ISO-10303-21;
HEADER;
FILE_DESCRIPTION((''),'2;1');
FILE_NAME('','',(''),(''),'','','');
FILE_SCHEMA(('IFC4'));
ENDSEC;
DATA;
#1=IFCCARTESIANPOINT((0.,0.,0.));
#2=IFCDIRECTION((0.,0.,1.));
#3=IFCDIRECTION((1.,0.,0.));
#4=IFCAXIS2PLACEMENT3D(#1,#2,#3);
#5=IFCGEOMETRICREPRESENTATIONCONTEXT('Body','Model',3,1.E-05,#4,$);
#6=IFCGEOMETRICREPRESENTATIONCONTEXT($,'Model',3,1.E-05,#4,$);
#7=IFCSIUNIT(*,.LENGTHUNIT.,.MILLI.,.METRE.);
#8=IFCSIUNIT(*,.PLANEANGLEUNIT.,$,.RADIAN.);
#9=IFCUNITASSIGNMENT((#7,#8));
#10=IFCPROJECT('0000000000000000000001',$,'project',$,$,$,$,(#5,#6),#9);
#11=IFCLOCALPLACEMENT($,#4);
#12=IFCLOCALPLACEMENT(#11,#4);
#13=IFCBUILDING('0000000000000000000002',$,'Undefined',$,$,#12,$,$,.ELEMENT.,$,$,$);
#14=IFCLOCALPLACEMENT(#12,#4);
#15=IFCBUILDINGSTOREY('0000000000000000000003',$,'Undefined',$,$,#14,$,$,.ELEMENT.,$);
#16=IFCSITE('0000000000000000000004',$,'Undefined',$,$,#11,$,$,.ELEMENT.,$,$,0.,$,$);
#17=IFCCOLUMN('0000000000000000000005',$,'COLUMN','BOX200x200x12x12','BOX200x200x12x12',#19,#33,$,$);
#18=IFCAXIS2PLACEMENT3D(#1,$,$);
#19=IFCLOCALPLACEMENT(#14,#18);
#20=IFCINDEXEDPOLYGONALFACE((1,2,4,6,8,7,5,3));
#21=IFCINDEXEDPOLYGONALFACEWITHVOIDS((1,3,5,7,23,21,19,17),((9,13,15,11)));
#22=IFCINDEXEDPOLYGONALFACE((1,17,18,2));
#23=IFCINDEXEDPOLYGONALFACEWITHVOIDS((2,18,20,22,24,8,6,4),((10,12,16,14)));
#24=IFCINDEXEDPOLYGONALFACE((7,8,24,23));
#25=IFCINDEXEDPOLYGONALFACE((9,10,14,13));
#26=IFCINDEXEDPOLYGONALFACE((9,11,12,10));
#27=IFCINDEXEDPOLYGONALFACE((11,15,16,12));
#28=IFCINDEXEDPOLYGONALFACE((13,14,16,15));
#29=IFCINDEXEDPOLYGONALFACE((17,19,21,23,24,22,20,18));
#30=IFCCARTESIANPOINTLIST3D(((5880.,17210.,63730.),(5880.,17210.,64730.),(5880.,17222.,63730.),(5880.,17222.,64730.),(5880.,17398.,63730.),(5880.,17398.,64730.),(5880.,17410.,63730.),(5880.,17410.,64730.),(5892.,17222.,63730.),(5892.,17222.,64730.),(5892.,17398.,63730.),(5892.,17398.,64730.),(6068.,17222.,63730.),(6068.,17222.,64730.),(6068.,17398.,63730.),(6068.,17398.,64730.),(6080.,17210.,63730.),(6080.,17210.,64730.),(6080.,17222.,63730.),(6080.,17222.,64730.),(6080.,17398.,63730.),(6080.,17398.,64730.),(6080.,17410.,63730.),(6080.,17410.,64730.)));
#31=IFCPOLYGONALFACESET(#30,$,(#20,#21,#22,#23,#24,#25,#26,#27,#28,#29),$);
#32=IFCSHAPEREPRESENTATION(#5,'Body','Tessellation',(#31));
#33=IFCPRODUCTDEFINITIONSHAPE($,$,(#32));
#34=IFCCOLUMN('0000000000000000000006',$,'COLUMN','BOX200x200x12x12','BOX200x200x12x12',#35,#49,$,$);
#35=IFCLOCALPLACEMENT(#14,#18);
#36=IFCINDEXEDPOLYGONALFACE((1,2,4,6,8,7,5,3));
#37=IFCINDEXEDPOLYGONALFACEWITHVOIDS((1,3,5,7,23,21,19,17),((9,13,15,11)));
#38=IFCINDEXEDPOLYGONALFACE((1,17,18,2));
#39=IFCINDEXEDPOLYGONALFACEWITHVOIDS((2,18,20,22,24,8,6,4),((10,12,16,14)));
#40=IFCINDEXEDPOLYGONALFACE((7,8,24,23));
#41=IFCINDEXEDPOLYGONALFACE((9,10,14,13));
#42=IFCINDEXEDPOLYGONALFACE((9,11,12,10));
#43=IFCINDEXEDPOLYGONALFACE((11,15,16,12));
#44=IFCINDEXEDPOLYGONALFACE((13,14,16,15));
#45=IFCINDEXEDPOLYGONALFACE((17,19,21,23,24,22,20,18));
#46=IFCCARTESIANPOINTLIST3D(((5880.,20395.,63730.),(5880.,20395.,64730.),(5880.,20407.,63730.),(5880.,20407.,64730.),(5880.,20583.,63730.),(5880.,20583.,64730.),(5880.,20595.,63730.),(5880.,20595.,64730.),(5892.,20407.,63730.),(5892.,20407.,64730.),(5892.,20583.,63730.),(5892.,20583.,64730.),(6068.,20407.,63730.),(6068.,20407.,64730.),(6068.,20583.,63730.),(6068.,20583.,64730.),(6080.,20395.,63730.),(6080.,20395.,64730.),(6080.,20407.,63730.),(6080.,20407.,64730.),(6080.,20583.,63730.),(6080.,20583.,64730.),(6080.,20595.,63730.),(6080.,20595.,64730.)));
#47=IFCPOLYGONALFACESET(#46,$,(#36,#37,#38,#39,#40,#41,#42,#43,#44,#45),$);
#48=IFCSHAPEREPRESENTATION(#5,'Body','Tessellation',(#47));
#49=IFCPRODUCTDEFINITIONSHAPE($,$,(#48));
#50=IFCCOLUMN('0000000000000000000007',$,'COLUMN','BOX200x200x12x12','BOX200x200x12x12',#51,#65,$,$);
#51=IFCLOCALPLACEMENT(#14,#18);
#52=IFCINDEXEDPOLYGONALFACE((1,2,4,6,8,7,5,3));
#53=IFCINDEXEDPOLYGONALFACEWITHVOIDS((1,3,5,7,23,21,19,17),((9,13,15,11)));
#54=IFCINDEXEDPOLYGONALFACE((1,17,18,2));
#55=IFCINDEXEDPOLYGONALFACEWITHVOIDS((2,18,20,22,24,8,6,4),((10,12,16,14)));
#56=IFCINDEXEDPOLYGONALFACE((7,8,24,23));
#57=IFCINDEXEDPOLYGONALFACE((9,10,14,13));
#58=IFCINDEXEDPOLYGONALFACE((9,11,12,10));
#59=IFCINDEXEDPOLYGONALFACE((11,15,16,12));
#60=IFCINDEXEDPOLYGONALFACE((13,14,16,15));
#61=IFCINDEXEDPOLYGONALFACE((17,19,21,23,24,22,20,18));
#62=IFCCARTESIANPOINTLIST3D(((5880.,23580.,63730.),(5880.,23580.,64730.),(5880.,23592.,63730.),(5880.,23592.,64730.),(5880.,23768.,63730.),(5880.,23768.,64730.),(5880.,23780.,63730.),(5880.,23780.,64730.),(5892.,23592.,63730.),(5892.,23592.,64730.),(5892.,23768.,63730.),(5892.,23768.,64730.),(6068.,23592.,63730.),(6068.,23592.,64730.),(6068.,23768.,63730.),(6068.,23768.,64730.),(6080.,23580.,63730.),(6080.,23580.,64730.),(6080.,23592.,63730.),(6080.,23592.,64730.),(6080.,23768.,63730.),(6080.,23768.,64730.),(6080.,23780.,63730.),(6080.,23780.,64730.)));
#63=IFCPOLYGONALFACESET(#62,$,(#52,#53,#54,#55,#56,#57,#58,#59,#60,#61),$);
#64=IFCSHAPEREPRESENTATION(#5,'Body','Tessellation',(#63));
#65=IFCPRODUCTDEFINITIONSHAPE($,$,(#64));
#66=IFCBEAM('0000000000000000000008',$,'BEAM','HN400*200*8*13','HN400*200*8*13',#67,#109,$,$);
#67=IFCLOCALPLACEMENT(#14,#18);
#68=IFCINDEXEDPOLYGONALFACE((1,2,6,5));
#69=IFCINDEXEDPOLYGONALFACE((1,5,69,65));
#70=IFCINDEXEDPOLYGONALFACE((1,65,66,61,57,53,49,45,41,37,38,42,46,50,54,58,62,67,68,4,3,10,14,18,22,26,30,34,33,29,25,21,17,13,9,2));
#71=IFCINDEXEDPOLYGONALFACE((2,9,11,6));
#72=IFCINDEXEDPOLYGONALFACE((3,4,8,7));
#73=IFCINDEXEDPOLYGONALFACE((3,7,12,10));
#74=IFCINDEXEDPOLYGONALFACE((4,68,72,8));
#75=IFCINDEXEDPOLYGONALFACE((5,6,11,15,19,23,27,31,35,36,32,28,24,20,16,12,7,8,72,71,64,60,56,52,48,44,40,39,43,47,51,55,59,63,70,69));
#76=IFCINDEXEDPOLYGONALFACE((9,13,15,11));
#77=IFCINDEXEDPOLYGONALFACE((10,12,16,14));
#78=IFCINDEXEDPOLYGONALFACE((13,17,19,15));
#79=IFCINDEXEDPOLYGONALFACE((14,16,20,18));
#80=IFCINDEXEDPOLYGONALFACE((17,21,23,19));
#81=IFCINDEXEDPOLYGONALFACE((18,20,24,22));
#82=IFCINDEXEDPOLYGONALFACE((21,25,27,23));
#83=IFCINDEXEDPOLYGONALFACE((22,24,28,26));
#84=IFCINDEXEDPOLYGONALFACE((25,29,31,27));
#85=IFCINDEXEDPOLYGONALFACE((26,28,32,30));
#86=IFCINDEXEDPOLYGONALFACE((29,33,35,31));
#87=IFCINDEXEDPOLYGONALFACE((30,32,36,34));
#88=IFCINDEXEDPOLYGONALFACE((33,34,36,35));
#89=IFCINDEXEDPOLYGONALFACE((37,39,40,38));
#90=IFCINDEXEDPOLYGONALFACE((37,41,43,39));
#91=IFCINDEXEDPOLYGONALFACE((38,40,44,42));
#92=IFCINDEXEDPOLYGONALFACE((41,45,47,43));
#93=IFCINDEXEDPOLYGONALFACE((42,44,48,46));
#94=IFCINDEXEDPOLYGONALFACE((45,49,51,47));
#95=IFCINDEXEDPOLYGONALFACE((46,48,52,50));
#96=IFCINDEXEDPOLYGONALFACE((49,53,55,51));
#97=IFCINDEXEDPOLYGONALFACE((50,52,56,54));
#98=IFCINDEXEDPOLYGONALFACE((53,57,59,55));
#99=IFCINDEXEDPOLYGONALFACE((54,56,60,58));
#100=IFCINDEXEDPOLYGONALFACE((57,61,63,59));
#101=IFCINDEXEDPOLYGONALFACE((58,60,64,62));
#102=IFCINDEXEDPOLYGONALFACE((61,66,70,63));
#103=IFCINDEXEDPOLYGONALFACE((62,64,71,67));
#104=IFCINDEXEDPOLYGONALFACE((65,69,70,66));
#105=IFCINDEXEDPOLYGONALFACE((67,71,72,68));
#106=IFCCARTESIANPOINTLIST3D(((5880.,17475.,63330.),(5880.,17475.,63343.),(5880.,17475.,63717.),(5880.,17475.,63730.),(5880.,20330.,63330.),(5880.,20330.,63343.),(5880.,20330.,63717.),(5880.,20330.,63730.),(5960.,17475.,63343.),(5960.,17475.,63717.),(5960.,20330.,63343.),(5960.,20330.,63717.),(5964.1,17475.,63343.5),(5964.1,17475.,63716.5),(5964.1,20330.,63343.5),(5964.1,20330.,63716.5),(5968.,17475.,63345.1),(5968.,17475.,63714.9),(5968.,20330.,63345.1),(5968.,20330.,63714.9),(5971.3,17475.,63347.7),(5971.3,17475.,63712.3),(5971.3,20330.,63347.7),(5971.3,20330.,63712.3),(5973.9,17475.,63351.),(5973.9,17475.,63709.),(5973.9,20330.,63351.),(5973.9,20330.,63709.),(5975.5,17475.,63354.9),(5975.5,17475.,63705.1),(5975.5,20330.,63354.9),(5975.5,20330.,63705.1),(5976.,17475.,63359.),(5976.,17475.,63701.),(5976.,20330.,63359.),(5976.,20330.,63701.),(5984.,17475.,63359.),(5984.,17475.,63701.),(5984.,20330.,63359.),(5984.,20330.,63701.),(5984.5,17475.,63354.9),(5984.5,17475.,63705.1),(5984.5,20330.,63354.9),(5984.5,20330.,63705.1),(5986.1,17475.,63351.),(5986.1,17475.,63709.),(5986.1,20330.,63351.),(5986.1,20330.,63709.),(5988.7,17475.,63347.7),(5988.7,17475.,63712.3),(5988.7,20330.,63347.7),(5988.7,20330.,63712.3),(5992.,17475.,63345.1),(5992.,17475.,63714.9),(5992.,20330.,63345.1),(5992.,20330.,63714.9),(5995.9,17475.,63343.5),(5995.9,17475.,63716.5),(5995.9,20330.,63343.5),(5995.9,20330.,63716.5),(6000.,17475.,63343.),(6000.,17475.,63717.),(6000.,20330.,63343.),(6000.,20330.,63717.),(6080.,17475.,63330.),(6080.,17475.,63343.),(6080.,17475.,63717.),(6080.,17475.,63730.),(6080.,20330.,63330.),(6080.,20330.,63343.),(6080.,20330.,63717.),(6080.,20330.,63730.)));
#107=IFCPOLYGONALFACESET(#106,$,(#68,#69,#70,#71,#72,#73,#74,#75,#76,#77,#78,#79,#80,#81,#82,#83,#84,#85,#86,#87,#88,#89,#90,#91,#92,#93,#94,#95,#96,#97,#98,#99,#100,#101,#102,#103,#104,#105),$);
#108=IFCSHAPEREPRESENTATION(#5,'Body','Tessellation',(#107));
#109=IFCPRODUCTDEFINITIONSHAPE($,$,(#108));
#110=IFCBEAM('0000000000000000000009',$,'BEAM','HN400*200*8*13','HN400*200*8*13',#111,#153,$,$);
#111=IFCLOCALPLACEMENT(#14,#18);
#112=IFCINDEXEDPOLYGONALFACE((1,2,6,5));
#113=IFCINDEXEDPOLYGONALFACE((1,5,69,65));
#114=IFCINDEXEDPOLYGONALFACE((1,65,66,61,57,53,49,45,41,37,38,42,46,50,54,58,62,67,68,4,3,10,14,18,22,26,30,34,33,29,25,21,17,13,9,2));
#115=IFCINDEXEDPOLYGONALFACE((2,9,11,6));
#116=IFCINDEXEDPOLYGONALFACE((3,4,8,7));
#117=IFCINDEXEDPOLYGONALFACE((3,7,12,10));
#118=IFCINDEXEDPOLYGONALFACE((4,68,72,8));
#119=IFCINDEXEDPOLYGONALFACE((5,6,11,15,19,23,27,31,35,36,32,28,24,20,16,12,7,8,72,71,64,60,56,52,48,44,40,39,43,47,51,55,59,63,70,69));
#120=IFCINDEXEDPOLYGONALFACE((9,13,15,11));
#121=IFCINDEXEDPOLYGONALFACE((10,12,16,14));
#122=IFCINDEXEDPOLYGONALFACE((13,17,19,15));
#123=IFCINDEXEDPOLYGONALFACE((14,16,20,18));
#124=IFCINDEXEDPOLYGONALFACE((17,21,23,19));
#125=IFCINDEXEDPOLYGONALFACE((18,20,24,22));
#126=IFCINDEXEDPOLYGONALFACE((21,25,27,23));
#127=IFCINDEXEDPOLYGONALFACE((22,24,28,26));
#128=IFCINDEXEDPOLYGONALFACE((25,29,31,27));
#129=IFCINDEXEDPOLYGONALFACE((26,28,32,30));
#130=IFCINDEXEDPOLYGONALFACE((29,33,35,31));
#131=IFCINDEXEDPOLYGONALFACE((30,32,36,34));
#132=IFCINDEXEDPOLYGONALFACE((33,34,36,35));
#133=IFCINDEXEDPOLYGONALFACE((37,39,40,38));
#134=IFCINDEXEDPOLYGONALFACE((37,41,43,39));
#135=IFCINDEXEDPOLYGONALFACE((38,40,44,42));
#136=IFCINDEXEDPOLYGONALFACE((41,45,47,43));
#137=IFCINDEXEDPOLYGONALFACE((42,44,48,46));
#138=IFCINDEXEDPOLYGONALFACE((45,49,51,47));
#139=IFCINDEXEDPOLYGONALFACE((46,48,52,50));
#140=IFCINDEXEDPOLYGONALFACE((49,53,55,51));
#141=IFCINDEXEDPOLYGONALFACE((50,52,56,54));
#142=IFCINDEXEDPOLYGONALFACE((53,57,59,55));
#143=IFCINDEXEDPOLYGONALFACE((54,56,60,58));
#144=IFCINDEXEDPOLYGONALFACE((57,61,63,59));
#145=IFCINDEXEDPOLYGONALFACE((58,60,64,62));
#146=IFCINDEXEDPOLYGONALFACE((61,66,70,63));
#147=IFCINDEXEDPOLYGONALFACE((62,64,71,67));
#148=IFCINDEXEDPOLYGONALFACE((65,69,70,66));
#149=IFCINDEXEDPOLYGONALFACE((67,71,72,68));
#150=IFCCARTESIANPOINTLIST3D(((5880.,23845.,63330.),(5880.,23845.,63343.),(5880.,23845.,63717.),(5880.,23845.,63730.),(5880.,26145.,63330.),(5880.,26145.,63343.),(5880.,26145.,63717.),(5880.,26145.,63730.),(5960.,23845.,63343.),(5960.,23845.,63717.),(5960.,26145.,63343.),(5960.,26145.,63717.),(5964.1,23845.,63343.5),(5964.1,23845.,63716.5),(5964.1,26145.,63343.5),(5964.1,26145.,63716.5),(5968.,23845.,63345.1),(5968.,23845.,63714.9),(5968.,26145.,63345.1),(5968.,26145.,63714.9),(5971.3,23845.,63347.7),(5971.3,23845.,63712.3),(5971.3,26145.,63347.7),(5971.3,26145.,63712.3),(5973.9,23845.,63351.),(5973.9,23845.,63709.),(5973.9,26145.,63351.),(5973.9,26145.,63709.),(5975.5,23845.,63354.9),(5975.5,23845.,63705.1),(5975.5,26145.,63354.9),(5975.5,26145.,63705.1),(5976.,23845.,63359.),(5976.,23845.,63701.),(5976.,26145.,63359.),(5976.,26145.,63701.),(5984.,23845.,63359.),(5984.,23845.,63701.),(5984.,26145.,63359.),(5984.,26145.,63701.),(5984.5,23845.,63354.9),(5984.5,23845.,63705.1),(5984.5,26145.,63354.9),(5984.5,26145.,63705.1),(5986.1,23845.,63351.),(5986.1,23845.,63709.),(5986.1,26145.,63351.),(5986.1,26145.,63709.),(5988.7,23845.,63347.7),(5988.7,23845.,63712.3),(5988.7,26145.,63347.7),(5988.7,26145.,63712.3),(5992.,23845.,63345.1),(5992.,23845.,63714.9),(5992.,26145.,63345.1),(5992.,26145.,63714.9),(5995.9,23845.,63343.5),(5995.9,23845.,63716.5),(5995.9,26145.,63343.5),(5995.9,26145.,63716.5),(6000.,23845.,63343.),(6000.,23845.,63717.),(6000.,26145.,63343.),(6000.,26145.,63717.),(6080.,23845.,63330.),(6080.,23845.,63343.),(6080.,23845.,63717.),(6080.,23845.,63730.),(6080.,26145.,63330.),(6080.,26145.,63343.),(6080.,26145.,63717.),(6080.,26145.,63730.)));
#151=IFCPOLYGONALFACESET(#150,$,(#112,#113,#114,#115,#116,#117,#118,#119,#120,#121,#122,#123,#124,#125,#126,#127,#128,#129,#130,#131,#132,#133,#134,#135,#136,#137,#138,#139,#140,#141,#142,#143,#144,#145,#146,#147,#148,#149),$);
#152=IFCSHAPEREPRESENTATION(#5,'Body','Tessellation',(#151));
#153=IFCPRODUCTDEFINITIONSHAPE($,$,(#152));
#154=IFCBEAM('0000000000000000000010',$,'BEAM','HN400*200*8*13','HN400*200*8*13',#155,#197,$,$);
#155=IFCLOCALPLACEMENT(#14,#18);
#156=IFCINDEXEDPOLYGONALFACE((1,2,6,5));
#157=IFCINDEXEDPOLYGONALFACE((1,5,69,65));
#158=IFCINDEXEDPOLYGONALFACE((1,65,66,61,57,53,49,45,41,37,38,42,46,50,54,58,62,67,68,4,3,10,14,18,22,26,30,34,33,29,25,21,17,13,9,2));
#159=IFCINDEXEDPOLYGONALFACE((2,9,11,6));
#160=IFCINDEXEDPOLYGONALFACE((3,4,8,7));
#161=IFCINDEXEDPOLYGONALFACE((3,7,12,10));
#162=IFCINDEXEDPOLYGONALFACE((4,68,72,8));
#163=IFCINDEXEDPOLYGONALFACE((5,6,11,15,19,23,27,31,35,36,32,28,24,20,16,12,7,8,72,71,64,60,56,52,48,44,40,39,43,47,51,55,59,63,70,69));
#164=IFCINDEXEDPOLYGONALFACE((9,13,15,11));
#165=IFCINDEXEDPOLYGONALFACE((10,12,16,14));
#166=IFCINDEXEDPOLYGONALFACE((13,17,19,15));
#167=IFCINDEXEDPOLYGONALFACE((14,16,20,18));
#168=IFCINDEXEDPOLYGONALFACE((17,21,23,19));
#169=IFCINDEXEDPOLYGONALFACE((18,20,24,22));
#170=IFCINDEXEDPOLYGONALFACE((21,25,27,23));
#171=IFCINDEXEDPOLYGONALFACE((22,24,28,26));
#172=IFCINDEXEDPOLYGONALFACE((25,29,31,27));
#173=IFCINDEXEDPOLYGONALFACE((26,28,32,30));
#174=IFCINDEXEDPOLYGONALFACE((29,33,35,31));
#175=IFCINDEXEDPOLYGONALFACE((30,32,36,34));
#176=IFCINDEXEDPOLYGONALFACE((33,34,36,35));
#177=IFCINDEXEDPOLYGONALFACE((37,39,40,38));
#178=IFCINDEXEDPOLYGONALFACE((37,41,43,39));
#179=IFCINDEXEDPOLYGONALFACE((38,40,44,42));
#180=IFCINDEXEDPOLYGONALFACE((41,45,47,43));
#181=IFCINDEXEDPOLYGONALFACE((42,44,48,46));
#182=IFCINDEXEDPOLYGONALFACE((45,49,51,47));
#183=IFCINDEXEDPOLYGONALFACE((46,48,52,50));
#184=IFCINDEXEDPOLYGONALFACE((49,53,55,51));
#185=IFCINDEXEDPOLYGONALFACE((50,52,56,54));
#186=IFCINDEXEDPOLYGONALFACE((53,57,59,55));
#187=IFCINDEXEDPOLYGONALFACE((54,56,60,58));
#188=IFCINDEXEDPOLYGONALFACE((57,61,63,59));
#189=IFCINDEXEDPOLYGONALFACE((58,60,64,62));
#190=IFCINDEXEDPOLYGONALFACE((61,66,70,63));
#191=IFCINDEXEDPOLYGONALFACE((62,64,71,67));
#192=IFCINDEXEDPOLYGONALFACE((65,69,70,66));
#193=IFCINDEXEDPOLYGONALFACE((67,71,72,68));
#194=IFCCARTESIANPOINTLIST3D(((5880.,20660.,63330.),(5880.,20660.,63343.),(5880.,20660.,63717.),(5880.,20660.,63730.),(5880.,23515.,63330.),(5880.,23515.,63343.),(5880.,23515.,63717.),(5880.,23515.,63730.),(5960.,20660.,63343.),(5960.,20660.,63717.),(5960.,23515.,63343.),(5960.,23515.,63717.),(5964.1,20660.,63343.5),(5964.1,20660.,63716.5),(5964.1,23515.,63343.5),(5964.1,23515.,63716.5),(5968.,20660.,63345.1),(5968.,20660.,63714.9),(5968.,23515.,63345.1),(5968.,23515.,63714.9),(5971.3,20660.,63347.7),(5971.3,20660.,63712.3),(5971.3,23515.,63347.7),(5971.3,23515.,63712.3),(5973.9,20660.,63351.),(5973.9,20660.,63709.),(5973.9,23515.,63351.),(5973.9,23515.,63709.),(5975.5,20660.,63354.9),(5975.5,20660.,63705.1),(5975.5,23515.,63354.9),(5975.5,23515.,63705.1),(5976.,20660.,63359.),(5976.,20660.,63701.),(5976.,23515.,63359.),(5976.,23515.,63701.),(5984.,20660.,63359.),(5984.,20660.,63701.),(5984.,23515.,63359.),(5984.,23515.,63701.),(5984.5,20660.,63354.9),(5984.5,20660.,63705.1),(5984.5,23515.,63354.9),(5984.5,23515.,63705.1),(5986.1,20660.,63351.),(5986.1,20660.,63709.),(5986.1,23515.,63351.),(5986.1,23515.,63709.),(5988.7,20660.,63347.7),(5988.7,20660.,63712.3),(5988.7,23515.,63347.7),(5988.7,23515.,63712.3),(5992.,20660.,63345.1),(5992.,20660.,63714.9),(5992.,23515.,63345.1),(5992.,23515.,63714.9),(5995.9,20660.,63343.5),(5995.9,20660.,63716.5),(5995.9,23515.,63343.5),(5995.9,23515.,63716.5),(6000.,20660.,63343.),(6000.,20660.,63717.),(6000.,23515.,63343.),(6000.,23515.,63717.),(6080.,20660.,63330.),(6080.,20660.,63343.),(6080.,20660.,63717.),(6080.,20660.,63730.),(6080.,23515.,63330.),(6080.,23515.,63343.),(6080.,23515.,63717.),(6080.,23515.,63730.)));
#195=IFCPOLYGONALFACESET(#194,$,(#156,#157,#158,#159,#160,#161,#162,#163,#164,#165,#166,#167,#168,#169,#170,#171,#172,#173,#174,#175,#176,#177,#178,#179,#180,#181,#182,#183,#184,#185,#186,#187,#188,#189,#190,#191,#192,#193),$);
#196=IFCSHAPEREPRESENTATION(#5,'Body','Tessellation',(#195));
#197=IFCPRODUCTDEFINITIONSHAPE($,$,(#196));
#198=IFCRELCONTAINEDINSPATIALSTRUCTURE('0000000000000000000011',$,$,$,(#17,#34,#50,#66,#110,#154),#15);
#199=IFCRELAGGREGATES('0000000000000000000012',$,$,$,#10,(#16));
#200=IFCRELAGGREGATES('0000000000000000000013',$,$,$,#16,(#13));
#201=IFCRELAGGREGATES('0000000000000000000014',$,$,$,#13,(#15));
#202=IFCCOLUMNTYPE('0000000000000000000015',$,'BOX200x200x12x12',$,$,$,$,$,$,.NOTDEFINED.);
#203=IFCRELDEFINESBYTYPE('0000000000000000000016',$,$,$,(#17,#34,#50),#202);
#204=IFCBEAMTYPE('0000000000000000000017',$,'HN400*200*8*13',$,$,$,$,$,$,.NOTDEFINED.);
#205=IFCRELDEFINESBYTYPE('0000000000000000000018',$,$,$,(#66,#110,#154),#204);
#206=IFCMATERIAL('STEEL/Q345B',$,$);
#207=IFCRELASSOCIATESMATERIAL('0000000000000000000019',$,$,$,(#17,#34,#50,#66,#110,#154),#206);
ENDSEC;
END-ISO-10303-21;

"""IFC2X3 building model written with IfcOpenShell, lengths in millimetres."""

from ifc_helpers import new_model, si_unit, frame, origin_with_axes, origin_2d_with_axis, place, context, project, spatial, polyline, i_section, outline, extrude, material, type_object, element, save


model = new_model("IFC2X3")

# Units and contexts
model_context_1 = context("Model", 3, precision=1e-05, world=origin_with_axes(), identifier="Body")
model_context_2 = context("Model", 3, precision=1e-05, world=origin_with_axes())
ifc_project = project(units=[si_unit("LENGTHUNIT", "METRE", prefix="MILLI"), si_unit("PLANEANGLEUNIT", "RADIAN")], contexts=[model_context_1, model_context_2])

# Site, building, storey
site_placement = place(None, origin_with_axes())
site = spatial("IfcSite", under=ifc_project, at=site_placement, Name="Undefined", CompositionType="ELEMENT", RefElevation=0.0)
building_placement = place(site_placement, origin_with_axes())
building = spatial("IfcBuilding", under=site, at=building_placement, Name="Undefined", CompositionType="ELEMENT")
storey_placement = place(building_placement, origin_with_axes())
storey = spatial("IfcBuildingStorey", under=building, at=storey_placement, Name="Undefined", CompositionType="ELEMENT")

# Columns
ifc_material_1 = material(Name="STEEL/Q345B")
column_type = type_object("IfcColumnType", Name="BOX200x200x12x12", PredefinedType="NOTDEFINED")
for number, where, z_axis, x_axis, name in (
    (1, (5980.0, 17310.0, 63730.0), (0.0, 0.0, 1.0), (1.0, 0.0, 0.0), "COLUMN"),
    (2, (5980.0, 20495.0, 63730.0), (0.0, 0.0, 1.0), (1.0, 0.0, 0.0), "COLUMN"),
    (3, (5980.0, 23680.0, 63730.0), (0.0, 0.0, 1.0), (1.0, 0.0, 0.0), "COLUMN"),
):
    element("IfcColumn", number, at=place(storey_placement, frame(where, z_axis=z_axis, x_axis=x_axis)), inside=storey, type_object=column_type, material=ifc_material_1, Name=name, Description="BOX200x200x12x12", ObjectType="BOX200x200x12x12", context=model_context_1, shape_type="SweptSolid", body=[
        extrude(outline(polyline([(-100.0, -100.0), (100.0, -100.0), (100.0, -88.0), (100.0, 88.0), (100.0, 100.0), (-100.0, 100.0), (-100.0, 88.0), (-100.0, -88.0), (-100.0, -100.0)]), holes=[polyline([(-88.0, -88.0), (-88.0, 88.0), (88.0, 88.0), (88.0, -88.0), (-88.0, -88.0)])]), frame((0.0, 0.0, 1000.0), z_axis=(0.0, 0.0, -1.0), x_axis=(-1.0, 0.0, 0.0)), (0.0, 0.0, 1.0), 1000.0),
    ])

# Beams
beam_type_1 = type_object("IfcBeamType", Name="HN400*200*8*13", PredefinedType="NOTDEFINED")
beam_1_placement = place(storey_placement, frame((5980.0, 17310.0, 63530.0), z_axis=(0.0, 0.0, 1.0), x_axis=(0.0, 1.0, 0.0)))
element("IfcBeam", 4, at=beam_1_placement, inside=storey, type_object=beam_type_1, material=ifc_material_1, Name="BEAM", Description="HN400*200*8*13", ObjectType="HN400*200*8*13", context=model_context_1, shape_type="SweptSolid", body=[
    extrude(i_section(OverallWidth=200.0, OverallDepth=400.0, WebThickness=8.0, FlangeThickness=13.0, FilletRadius=16.0, at=origin_2d_with_axis()), frame((3020.0, 0.0, 0.0), z_axis=(-1.0, 0.0, 0.0), x_axis=(0.0, -1.0, 0.0)), (0.0, 0.0, 1.0), 2855.0),
])
beam_2_placement = place(storey_placement, frame((5980.0, 23680.0, 63530.0), z_axis=(0.0, 0.0, 1.0), x_axis=(0.0, 1.0, 0.0)))
element("IfcBeam", 5, at=beam_2_placement, inside=storey, type_object=beam_type_1, material=ifc_material_1, Name="BEAM", Description="HN400*200*8*13", ObjectType="HN400*200*8*13", context=model_context_1, shape_type="SweptSolid", body=[
    extrude(i_section(OverallWidth=200.0, OverallDepth=400.0, WebThickness=8.0, FlangeThickness=13.0, FilletRadius=16.0, at=origin_2d_with_axis()), frame((2465.0, 0.0, 0.0), z_axis=(-1.0, 0.0, 0.0), x_axis=(0.0, -1.0, 0.0)), (0.0, 0.0, 1.0), 2300.0),
])
beam_3_placement = place(storey_placement, frame((5980.0, 20464.4, 63530.0), z_axis=(0.0, 0.0, 1.0), x_axis=(0.0, 1.0, 0.0)))
element("IfcBeam", 6, at=beam_3_placement, inside=storey, type_object=beam_type_1, material=ifc_material_1, Name="BEAM", Description="HN400*200*8*13", ObjectType="HN400*200*8*13", context=model_context_1, shape_type="SweptSolid", body=[
    extrude(i_section(OverallWidth=200.0, OverallDepth=400.0, WebThickness=8.0, FlangeThickness=13.0, FilletRadius=16.0, at=origin_2d_with_axis()), frame((3050.6, 0.0, 0.0), z_axis=(-1.0, 0.0, 0.0), x_axis=(0.0, -1.0, 0.0)), (0.0, 0.0, 1.0), 2855.0),
])

save(model, "model.ifc")
